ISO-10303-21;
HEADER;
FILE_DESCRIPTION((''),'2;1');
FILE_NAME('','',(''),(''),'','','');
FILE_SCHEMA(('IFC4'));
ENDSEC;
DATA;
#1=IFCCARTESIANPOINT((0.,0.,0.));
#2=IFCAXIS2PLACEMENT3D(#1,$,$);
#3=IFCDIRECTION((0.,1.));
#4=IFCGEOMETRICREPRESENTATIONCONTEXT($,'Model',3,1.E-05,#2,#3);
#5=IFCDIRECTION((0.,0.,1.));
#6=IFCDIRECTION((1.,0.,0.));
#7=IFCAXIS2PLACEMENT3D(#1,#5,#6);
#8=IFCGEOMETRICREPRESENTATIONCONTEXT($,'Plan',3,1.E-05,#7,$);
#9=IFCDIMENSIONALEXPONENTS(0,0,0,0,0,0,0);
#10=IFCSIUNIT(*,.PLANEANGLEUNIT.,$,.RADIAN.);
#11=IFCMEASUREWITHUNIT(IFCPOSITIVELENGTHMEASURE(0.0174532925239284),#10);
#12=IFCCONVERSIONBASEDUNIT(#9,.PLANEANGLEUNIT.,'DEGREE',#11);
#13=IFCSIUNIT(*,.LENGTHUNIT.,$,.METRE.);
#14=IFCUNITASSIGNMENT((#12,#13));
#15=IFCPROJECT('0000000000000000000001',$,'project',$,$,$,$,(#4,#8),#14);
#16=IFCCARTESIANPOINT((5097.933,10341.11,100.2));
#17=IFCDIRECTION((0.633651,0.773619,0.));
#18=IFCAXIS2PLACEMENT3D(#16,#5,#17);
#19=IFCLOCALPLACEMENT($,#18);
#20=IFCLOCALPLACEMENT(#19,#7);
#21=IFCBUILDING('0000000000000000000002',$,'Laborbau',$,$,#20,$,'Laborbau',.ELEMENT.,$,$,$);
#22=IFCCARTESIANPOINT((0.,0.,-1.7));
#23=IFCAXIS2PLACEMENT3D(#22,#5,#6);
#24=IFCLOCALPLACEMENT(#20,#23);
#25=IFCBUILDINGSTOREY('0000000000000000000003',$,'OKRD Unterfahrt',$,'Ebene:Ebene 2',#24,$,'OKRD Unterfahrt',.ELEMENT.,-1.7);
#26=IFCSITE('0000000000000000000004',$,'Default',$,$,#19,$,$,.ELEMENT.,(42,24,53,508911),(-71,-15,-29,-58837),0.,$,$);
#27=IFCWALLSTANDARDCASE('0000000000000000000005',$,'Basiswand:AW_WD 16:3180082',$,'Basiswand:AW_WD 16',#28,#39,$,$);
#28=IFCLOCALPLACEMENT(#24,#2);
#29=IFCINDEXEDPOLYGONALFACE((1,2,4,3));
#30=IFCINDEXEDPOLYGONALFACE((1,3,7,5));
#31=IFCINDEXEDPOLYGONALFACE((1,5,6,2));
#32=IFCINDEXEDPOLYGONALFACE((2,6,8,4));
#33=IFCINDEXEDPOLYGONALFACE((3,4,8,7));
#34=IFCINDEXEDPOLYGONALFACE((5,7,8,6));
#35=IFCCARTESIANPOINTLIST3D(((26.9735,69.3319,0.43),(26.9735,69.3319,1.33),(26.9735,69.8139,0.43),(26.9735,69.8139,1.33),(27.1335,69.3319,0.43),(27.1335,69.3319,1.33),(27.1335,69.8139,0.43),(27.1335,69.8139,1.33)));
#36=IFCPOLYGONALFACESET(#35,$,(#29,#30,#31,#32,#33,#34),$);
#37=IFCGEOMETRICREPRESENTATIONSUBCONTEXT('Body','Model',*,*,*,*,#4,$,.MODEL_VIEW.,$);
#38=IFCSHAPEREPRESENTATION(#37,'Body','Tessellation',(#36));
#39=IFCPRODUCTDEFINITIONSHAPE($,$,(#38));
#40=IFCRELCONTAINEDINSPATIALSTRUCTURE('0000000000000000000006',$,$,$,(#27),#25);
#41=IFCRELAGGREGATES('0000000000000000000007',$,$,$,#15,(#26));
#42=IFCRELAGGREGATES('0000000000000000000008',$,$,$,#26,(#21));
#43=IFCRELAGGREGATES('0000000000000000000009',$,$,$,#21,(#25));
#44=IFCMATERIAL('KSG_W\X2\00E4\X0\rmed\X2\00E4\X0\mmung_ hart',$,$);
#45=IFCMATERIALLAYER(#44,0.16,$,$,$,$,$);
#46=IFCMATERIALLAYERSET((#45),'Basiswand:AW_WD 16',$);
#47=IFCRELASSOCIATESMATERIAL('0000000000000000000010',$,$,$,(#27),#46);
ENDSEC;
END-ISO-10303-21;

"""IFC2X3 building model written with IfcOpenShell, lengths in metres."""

from ifc_helpers import new_model, entity, si_unit, converted_unit, direction, frame, frame_2d, origin, origin_with_axes, place, context, subcontext, project, spatial, rectangle, extrude, material, layer, layer_set, layer_usage, element, save


model = new_model("IFC2X3")

# Units and contexts
model_context = context("Model", 3, precision=1e-05, world=origin(), true_north=direction((0.0, 1.0)))
plan_context = context("Plan", 3, precision=1e-05, world=origin_with_axes())
body_context = subcontext(model_context, "Body", "Model", "MODEL_VIEW")
ifc_project = project(units=[converted_unit("PLANEANGLEUNIT", "DEGREE", entity("IfcPositiveLengthMeasure", 0.0174532925239284), si_unit("PLANEANGLEUNIT", "RADIAN"), dimensions=[0, 0, 0, 0, 0, 0, 0]), si_unit("LENGTHUNIT", "METRE")], contexts=[model_context, plan_context])

# Site, building, storey
site_placement = place(None, frame((5097.933, 10341.11, 100.2), z_axis=(0.0, 0.0, 1.0), x_axis=(0.633651, 0.773619, 0.0)))
site = spatial("IfcSite", under=ifc_project, at=site_placement, Name="Default", CompositionType="ELEMENT", RefLatitude=(42, 24, 53, 508911), RefLongitude=(-71, -15, -29, -58837), RefElevation=0.0)
building_placement = place(site_placement, origin_with_axes())
building = spatial("IfcBuilding", under=site, at=building_placement, Name="Laborbau", LongName="Laborbau", CompositionType="ELEMENT")
storey_placement = place(building_placement, frame((0.0, 0.0, -1.7), z_axis=(0.0, 0.0, 1.0), x_axis=(1.0, 0.0, 0.0)))
storey = spatial("IfcBuildingStorey", under=building, at=storey_placement, Name="OKRD Unterfahrt", ObjectType="Ebene:Ebene 2", LongName="OKRD Unterfahrt", CompositionType="ELEMENT", Elevation=-1.7)

# Shared definitions
ifc_material_1 = material(Name="KSG_Wärmedämmung_ hart")

# Wall
ifc_layer_1 = layer(ifc_material_1, 0.16)
ifc_layer_set_1 = layer_set([ifc_layer_1], Name="Basiswand:AW_WD 16")
ifc_layer_usage_1 = layer_usage(ifc_layer_set_1, "AXIS2", "NEGATIVE", 0.08)
wall_1_placement = place(storey_placement, frame((27.0535, 69.3319, 0.43), z_axis=(0.0, 0.0, 1.0), x_axis=(0.0, 1.0, 0.0)))
element("IfcWallStandardCase", 1, at=wall_1_placement, inside=storey, material=ifc_layer_usage_1, Name="Basiswand:AW_WD 16:3180082", ObjectType="Basiswand:AW_WD 16", context=body_context, shape_type="SweptSolid", body=[
    extrude(rectangle(XDim=0.4819, YDim=0.16, at=frame_2d((0.241, 0.0), x_axis=(-1.0, 0.0))), origin(), (0.0, 0.0, 1.0), 0.9),
])

save(model, "model.ifc")
